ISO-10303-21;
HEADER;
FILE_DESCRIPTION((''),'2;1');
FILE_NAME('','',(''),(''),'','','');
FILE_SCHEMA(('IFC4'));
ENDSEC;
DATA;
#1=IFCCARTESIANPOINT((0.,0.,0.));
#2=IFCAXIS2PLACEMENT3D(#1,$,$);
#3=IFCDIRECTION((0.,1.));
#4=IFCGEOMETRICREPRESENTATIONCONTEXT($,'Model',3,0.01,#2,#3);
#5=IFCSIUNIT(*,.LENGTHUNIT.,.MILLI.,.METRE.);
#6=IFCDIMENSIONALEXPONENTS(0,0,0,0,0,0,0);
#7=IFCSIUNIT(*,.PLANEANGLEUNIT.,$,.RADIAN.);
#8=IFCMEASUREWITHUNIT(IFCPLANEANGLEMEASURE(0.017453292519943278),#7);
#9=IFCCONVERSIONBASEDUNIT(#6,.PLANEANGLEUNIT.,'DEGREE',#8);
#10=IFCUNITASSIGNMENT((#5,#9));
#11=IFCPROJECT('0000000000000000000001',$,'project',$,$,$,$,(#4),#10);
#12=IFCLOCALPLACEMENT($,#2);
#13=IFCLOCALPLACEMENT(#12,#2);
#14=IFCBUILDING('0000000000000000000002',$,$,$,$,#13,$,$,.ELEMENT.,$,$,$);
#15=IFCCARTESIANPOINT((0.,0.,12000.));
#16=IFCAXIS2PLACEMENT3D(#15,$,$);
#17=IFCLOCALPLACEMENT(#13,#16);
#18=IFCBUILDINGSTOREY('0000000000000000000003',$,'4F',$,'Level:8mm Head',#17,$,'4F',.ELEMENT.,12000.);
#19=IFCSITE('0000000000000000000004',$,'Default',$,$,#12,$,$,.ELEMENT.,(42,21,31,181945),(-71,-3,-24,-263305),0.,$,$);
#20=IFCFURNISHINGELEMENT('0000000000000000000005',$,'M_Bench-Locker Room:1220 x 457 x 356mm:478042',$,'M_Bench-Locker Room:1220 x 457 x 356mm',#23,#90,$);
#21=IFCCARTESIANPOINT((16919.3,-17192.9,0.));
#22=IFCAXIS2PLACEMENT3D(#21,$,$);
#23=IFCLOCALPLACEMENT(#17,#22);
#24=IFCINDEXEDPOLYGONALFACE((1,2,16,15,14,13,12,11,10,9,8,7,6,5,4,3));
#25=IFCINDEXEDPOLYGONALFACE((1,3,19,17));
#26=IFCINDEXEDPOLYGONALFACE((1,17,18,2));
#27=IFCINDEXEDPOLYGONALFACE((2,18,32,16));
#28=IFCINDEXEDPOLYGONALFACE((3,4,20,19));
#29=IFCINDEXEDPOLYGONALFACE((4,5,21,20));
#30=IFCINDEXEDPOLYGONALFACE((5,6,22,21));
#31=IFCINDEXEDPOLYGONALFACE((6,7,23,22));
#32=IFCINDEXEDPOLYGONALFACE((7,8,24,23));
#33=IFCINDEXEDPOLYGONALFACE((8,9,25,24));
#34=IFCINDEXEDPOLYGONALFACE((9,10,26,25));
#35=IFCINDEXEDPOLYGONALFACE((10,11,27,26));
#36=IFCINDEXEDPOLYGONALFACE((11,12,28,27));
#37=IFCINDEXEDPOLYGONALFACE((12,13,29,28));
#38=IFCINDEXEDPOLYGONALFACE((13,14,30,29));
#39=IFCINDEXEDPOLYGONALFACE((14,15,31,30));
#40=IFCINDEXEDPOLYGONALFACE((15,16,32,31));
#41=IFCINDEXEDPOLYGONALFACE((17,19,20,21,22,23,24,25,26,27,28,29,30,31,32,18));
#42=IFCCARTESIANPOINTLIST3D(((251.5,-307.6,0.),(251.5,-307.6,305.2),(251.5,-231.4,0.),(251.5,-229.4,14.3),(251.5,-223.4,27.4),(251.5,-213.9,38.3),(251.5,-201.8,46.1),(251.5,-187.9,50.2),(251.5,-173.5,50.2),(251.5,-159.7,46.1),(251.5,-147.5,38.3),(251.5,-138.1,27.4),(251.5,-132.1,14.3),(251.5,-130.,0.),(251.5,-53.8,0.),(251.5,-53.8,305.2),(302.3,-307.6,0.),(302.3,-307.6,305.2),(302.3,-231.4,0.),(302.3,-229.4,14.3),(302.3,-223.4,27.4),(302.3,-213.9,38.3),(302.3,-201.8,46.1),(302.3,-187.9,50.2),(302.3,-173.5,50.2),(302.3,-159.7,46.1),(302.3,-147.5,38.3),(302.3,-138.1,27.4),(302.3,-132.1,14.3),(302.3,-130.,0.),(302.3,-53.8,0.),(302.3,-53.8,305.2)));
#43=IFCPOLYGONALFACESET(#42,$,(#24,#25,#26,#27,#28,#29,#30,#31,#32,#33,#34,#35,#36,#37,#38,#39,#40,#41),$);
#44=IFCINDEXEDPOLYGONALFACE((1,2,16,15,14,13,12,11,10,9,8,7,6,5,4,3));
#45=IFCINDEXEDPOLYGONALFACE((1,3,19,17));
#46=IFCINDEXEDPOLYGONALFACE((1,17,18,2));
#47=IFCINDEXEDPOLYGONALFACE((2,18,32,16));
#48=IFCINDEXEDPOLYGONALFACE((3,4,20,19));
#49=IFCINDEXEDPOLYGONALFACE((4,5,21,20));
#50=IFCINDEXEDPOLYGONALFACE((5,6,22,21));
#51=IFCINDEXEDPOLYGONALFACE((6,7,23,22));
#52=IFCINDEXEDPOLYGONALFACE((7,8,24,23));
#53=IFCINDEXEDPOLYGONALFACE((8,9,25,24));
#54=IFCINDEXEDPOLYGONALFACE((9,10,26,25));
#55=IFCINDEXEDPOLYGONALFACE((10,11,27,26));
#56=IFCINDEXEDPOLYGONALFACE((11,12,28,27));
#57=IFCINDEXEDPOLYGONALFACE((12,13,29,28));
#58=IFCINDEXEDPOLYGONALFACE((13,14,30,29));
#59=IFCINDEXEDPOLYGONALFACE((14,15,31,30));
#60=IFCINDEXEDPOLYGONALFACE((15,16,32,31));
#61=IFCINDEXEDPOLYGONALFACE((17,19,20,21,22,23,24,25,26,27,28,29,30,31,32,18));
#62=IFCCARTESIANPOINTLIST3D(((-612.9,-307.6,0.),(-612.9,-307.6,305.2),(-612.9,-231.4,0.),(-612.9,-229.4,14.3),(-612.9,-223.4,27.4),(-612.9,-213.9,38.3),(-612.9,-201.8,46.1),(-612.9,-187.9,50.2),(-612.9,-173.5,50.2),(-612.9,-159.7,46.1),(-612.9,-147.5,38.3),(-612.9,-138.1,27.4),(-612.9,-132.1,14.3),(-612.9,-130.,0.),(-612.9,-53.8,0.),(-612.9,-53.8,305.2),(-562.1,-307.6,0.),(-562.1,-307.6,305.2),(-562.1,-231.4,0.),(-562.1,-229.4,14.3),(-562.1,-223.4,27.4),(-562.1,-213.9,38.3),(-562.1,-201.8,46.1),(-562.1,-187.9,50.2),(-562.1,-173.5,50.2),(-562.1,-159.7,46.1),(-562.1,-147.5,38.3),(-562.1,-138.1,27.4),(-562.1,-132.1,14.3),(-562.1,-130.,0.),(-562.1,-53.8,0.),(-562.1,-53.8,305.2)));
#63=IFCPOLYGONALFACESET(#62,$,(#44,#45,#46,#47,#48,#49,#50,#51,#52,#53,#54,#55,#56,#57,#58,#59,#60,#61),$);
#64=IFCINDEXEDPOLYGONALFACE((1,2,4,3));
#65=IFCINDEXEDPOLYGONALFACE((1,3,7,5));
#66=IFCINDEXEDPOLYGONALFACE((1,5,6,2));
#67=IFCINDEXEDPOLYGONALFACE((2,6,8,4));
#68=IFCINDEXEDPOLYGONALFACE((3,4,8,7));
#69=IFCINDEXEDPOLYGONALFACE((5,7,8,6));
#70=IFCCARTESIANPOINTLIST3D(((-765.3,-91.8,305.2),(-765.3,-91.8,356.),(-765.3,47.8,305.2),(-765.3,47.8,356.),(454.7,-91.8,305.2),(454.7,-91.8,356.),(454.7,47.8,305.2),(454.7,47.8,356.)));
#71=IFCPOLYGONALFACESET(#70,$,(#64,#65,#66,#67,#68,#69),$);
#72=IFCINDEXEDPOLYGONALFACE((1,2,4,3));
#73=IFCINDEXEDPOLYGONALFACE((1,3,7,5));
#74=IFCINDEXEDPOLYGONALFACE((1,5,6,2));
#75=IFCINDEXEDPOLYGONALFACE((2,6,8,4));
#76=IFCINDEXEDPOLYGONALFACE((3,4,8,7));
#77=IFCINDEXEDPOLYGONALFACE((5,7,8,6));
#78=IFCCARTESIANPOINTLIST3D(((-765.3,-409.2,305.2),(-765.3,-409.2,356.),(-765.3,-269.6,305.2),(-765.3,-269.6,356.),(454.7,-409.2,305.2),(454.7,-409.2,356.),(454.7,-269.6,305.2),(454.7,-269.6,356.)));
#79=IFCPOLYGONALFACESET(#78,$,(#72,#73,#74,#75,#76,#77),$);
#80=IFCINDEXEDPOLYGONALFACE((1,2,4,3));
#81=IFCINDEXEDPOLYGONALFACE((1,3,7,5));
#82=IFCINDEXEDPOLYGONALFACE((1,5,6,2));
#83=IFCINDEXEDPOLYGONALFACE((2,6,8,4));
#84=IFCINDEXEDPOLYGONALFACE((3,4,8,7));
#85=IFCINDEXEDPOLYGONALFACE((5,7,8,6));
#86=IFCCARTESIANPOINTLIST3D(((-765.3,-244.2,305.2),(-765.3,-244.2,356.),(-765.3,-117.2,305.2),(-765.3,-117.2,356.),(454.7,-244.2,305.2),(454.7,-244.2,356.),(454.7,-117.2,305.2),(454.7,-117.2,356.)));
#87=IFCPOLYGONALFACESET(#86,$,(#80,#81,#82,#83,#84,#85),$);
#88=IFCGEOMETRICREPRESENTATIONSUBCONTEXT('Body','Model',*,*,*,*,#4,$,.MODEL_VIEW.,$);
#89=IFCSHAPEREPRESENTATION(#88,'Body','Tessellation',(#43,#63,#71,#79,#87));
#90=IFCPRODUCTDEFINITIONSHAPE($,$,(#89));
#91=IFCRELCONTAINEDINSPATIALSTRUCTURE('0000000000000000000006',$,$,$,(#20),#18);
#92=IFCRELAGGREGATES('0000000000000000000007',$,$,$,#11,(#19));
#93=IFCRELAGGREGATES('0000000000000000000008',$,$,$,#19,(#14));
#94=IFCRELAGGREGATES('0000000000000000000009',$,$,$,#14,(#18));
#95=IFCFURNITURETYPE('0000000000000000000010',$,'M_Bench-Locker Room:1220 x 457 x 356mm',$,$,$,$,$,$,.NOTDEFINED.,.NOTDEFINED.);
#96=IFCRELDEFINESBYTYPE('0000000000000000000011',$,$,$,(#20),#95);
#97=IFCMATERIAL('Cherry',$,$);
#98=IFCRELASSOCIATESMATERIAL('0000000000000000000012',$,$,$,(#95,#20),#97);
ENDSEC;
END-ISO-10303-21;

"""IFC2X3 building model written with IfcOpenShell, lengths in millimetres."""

from ifc_helpers import new_model, entity, si_unit, converted_unit, direction, frame, frame_2d, origin, origin_2d_with_axis, place, context, subcontext, project, spatial, polyline, circle_curve, parameter, trimmed, segment, composite_curve, rectangle, outline, extrude, source, transform, mapped, material, type_object, type_shapes, element, save


model = new_model("IFC2X3")

# Units and contexts
model_context = context("Model", 3, precision=0.01, world=origin(), true_north=direction((0.0, 1.0)))
body_context = subcontext(model_context, "Body", "Model", "MODEL_VIEW")
ifc_project = project(units=[si_unit("LENGTHUNIT", "METRE", prefix="MILLI"), converted_unit("PLANEANGLEUNIT", "DEGREE", entity("IfcPlaneAngleMeasure", 0.017453292519943278), si_unit("PLANEANGLEUNIT", "RADIAN"), dimensions=[0, 0, 0, 0, 0, 0, 0])], contexts=[model_context])

# Site, building, storey
site_placement = place(None, origin())
site = spatial("IfcSite", under=ifc_project, at=site_placement, Name="Default", CompositionType="ELEMENT", RefLatitude=(42, 21, 31, 181945), RefLongitude=(-71, -3, -24, -263305), RefElevation=0.0)
building_placement = place(site_placement, origin())
building = spatial("IfcBuilding", under=site, at=building_placement, CompositionType="ELEMENT")
storey_placement = place(building_placement, frame((0.0, 0.0, 12000.0)))
storey = spatial("IfcBuildingStorey", under=building, at=storey_placement, Name="4F", ObjectType="Level:8mm Head", LongName="4F", CompositionType="ELEMENT", Elevation=12000.0)

# Furnishing element
ifc_material_1 = material(Name="Cherry")
furniture_type = type_object("IfcFurnitureType", Name="M_Bench-Locker Room:1220 x 457 x 356mm", AssemblyPlace="NOTDEFINED", material=ifc_material_1)
shared_shape = source(origin(), body_context, "Body", "SweptSolid", [
    extrude(outline(composite_curve([segment(polyline([(-126.9, 101.7), (-126.9, -203.5)]), True, "CONTINUOUS"), segment(polyline([(-126.9, -203.5), (126.9, -203.5)]), True, "CONTINUOUS"), segment(polyline([(126.9, -203.5), (126.9, 101.7)]), True, "CONTINUOUS"), segment(polyline([(126.9, 101.7), (50.7, 101.7)]), True, "CONTINUOUS"), segment(trimmed(circle_curve(frame_2d((0.0, 101.7), x_axis=(0.0, 1.0)), 50.7), [parameter(90.0)], [parameter(270.0)], True, "PARAMETER"), False, "CONTINUOUS"), segment(polyline([(-50.7, 101.7), (-126.9, 101.7)]), True, "CONTINUOUS")], self_intersect=False)), frame((251.5, -180.7, 101.7), z_axis=(-1.0, 0.0, 0.0), x_axis=(0.0, 1.0, 0.0)), (0.0, 0.0, -1.0), 50.8),
    extrude(outline(composite_curve([segment(polyline([(-101.7, -126.9), (203.5, -126.9)]), True, "CONTINUOUS"), segment(polyline([(203.5, -126.9), (203.5, 126.9)]), True, "CONTINUOUS"), segment(polyline([(203.5, 126.9), (-101.7, 126.9)]), True, "CONTINUOUS"), segment(polyline([(-101.7, 126.9), (-101.7, 50.7)]), True, "CONTINUOUS"), segment(trimmed(circle_curve(frame_2d((-101.7, 0.0), x_axis=(-1.0, 0.0)), 50.7), [parameter(90.0)], [parameter(270.0)], True, "PARAMETER"), False, "CONTINUOUS"), segment(polyline([(-101.7, -50.7), (-101.7, -126.9)]), True, "CONTINUOUS")], self_intersect=False)), frame((-612.9, -180.7, 101.7), z_axis=(1.0, 0.0, 0.0), x_axis=(0.0, 0.0, 1.0)), (0.0, 0.0, 1.0), 50.8),
    extrude(rectangle(XDim=1220.0, YDim=139.6, at=origin_2d_with_axis()), frame((-155.3, -22.0, 305.2), z_axis=(0.0, 0.0, 1.0), x_axis=(-1.0, 0.0, 0.0)), (0.0, 0.0, 1.0), 50.8),
    extrude(rectangle(XDim=139.6, YDim=1220.0, at=frame_2d((0.0, 0.0), x_axis=(1.0, 0.0))), frame((-155.3, -339.4, 305.2), z_axis=(0.0, 0.0, 1.0), x_axis=(0.0, 1.0, 0.0)), (0.0, 0.0, 1.0), 50.8),
    extrude(rectangle(XDim=1220.0, YDim=126.9, at=frame_2d((0.0, 0.0), x_axis=(1.0, 0.0))), frame((-155.3, -180.7, 305.2), z_axis=(0.0, 0.0, 1.0), x_axis=(-1.0, 0.0, 0.0)), (0.0, 0.0, 1.0), 50.8),
])
type_shapes(furniture_type, [shared_shape])
for number, where, name in (
    (1, (16919.3, -17192.9, 0.0), "M_Bench-Locker Room:1220 x 457 x 356mm:478042"),
):
    element("IfcFurnishingElement", number, at=place(storey_placement, frame(where)), inside=storey, type_object=furniture_type, material=ifc_material_1, Name=name, ObjectType="M_Bench-Locker Room:1220 x 457 x 356mm", context=body_context, shape_type="MappedRepresentation", body=[
        mapped(shared_shape, transform((0.0, 0.0, 0.0), scale=1.0)),
    ])

save(model, "model.ifc")
